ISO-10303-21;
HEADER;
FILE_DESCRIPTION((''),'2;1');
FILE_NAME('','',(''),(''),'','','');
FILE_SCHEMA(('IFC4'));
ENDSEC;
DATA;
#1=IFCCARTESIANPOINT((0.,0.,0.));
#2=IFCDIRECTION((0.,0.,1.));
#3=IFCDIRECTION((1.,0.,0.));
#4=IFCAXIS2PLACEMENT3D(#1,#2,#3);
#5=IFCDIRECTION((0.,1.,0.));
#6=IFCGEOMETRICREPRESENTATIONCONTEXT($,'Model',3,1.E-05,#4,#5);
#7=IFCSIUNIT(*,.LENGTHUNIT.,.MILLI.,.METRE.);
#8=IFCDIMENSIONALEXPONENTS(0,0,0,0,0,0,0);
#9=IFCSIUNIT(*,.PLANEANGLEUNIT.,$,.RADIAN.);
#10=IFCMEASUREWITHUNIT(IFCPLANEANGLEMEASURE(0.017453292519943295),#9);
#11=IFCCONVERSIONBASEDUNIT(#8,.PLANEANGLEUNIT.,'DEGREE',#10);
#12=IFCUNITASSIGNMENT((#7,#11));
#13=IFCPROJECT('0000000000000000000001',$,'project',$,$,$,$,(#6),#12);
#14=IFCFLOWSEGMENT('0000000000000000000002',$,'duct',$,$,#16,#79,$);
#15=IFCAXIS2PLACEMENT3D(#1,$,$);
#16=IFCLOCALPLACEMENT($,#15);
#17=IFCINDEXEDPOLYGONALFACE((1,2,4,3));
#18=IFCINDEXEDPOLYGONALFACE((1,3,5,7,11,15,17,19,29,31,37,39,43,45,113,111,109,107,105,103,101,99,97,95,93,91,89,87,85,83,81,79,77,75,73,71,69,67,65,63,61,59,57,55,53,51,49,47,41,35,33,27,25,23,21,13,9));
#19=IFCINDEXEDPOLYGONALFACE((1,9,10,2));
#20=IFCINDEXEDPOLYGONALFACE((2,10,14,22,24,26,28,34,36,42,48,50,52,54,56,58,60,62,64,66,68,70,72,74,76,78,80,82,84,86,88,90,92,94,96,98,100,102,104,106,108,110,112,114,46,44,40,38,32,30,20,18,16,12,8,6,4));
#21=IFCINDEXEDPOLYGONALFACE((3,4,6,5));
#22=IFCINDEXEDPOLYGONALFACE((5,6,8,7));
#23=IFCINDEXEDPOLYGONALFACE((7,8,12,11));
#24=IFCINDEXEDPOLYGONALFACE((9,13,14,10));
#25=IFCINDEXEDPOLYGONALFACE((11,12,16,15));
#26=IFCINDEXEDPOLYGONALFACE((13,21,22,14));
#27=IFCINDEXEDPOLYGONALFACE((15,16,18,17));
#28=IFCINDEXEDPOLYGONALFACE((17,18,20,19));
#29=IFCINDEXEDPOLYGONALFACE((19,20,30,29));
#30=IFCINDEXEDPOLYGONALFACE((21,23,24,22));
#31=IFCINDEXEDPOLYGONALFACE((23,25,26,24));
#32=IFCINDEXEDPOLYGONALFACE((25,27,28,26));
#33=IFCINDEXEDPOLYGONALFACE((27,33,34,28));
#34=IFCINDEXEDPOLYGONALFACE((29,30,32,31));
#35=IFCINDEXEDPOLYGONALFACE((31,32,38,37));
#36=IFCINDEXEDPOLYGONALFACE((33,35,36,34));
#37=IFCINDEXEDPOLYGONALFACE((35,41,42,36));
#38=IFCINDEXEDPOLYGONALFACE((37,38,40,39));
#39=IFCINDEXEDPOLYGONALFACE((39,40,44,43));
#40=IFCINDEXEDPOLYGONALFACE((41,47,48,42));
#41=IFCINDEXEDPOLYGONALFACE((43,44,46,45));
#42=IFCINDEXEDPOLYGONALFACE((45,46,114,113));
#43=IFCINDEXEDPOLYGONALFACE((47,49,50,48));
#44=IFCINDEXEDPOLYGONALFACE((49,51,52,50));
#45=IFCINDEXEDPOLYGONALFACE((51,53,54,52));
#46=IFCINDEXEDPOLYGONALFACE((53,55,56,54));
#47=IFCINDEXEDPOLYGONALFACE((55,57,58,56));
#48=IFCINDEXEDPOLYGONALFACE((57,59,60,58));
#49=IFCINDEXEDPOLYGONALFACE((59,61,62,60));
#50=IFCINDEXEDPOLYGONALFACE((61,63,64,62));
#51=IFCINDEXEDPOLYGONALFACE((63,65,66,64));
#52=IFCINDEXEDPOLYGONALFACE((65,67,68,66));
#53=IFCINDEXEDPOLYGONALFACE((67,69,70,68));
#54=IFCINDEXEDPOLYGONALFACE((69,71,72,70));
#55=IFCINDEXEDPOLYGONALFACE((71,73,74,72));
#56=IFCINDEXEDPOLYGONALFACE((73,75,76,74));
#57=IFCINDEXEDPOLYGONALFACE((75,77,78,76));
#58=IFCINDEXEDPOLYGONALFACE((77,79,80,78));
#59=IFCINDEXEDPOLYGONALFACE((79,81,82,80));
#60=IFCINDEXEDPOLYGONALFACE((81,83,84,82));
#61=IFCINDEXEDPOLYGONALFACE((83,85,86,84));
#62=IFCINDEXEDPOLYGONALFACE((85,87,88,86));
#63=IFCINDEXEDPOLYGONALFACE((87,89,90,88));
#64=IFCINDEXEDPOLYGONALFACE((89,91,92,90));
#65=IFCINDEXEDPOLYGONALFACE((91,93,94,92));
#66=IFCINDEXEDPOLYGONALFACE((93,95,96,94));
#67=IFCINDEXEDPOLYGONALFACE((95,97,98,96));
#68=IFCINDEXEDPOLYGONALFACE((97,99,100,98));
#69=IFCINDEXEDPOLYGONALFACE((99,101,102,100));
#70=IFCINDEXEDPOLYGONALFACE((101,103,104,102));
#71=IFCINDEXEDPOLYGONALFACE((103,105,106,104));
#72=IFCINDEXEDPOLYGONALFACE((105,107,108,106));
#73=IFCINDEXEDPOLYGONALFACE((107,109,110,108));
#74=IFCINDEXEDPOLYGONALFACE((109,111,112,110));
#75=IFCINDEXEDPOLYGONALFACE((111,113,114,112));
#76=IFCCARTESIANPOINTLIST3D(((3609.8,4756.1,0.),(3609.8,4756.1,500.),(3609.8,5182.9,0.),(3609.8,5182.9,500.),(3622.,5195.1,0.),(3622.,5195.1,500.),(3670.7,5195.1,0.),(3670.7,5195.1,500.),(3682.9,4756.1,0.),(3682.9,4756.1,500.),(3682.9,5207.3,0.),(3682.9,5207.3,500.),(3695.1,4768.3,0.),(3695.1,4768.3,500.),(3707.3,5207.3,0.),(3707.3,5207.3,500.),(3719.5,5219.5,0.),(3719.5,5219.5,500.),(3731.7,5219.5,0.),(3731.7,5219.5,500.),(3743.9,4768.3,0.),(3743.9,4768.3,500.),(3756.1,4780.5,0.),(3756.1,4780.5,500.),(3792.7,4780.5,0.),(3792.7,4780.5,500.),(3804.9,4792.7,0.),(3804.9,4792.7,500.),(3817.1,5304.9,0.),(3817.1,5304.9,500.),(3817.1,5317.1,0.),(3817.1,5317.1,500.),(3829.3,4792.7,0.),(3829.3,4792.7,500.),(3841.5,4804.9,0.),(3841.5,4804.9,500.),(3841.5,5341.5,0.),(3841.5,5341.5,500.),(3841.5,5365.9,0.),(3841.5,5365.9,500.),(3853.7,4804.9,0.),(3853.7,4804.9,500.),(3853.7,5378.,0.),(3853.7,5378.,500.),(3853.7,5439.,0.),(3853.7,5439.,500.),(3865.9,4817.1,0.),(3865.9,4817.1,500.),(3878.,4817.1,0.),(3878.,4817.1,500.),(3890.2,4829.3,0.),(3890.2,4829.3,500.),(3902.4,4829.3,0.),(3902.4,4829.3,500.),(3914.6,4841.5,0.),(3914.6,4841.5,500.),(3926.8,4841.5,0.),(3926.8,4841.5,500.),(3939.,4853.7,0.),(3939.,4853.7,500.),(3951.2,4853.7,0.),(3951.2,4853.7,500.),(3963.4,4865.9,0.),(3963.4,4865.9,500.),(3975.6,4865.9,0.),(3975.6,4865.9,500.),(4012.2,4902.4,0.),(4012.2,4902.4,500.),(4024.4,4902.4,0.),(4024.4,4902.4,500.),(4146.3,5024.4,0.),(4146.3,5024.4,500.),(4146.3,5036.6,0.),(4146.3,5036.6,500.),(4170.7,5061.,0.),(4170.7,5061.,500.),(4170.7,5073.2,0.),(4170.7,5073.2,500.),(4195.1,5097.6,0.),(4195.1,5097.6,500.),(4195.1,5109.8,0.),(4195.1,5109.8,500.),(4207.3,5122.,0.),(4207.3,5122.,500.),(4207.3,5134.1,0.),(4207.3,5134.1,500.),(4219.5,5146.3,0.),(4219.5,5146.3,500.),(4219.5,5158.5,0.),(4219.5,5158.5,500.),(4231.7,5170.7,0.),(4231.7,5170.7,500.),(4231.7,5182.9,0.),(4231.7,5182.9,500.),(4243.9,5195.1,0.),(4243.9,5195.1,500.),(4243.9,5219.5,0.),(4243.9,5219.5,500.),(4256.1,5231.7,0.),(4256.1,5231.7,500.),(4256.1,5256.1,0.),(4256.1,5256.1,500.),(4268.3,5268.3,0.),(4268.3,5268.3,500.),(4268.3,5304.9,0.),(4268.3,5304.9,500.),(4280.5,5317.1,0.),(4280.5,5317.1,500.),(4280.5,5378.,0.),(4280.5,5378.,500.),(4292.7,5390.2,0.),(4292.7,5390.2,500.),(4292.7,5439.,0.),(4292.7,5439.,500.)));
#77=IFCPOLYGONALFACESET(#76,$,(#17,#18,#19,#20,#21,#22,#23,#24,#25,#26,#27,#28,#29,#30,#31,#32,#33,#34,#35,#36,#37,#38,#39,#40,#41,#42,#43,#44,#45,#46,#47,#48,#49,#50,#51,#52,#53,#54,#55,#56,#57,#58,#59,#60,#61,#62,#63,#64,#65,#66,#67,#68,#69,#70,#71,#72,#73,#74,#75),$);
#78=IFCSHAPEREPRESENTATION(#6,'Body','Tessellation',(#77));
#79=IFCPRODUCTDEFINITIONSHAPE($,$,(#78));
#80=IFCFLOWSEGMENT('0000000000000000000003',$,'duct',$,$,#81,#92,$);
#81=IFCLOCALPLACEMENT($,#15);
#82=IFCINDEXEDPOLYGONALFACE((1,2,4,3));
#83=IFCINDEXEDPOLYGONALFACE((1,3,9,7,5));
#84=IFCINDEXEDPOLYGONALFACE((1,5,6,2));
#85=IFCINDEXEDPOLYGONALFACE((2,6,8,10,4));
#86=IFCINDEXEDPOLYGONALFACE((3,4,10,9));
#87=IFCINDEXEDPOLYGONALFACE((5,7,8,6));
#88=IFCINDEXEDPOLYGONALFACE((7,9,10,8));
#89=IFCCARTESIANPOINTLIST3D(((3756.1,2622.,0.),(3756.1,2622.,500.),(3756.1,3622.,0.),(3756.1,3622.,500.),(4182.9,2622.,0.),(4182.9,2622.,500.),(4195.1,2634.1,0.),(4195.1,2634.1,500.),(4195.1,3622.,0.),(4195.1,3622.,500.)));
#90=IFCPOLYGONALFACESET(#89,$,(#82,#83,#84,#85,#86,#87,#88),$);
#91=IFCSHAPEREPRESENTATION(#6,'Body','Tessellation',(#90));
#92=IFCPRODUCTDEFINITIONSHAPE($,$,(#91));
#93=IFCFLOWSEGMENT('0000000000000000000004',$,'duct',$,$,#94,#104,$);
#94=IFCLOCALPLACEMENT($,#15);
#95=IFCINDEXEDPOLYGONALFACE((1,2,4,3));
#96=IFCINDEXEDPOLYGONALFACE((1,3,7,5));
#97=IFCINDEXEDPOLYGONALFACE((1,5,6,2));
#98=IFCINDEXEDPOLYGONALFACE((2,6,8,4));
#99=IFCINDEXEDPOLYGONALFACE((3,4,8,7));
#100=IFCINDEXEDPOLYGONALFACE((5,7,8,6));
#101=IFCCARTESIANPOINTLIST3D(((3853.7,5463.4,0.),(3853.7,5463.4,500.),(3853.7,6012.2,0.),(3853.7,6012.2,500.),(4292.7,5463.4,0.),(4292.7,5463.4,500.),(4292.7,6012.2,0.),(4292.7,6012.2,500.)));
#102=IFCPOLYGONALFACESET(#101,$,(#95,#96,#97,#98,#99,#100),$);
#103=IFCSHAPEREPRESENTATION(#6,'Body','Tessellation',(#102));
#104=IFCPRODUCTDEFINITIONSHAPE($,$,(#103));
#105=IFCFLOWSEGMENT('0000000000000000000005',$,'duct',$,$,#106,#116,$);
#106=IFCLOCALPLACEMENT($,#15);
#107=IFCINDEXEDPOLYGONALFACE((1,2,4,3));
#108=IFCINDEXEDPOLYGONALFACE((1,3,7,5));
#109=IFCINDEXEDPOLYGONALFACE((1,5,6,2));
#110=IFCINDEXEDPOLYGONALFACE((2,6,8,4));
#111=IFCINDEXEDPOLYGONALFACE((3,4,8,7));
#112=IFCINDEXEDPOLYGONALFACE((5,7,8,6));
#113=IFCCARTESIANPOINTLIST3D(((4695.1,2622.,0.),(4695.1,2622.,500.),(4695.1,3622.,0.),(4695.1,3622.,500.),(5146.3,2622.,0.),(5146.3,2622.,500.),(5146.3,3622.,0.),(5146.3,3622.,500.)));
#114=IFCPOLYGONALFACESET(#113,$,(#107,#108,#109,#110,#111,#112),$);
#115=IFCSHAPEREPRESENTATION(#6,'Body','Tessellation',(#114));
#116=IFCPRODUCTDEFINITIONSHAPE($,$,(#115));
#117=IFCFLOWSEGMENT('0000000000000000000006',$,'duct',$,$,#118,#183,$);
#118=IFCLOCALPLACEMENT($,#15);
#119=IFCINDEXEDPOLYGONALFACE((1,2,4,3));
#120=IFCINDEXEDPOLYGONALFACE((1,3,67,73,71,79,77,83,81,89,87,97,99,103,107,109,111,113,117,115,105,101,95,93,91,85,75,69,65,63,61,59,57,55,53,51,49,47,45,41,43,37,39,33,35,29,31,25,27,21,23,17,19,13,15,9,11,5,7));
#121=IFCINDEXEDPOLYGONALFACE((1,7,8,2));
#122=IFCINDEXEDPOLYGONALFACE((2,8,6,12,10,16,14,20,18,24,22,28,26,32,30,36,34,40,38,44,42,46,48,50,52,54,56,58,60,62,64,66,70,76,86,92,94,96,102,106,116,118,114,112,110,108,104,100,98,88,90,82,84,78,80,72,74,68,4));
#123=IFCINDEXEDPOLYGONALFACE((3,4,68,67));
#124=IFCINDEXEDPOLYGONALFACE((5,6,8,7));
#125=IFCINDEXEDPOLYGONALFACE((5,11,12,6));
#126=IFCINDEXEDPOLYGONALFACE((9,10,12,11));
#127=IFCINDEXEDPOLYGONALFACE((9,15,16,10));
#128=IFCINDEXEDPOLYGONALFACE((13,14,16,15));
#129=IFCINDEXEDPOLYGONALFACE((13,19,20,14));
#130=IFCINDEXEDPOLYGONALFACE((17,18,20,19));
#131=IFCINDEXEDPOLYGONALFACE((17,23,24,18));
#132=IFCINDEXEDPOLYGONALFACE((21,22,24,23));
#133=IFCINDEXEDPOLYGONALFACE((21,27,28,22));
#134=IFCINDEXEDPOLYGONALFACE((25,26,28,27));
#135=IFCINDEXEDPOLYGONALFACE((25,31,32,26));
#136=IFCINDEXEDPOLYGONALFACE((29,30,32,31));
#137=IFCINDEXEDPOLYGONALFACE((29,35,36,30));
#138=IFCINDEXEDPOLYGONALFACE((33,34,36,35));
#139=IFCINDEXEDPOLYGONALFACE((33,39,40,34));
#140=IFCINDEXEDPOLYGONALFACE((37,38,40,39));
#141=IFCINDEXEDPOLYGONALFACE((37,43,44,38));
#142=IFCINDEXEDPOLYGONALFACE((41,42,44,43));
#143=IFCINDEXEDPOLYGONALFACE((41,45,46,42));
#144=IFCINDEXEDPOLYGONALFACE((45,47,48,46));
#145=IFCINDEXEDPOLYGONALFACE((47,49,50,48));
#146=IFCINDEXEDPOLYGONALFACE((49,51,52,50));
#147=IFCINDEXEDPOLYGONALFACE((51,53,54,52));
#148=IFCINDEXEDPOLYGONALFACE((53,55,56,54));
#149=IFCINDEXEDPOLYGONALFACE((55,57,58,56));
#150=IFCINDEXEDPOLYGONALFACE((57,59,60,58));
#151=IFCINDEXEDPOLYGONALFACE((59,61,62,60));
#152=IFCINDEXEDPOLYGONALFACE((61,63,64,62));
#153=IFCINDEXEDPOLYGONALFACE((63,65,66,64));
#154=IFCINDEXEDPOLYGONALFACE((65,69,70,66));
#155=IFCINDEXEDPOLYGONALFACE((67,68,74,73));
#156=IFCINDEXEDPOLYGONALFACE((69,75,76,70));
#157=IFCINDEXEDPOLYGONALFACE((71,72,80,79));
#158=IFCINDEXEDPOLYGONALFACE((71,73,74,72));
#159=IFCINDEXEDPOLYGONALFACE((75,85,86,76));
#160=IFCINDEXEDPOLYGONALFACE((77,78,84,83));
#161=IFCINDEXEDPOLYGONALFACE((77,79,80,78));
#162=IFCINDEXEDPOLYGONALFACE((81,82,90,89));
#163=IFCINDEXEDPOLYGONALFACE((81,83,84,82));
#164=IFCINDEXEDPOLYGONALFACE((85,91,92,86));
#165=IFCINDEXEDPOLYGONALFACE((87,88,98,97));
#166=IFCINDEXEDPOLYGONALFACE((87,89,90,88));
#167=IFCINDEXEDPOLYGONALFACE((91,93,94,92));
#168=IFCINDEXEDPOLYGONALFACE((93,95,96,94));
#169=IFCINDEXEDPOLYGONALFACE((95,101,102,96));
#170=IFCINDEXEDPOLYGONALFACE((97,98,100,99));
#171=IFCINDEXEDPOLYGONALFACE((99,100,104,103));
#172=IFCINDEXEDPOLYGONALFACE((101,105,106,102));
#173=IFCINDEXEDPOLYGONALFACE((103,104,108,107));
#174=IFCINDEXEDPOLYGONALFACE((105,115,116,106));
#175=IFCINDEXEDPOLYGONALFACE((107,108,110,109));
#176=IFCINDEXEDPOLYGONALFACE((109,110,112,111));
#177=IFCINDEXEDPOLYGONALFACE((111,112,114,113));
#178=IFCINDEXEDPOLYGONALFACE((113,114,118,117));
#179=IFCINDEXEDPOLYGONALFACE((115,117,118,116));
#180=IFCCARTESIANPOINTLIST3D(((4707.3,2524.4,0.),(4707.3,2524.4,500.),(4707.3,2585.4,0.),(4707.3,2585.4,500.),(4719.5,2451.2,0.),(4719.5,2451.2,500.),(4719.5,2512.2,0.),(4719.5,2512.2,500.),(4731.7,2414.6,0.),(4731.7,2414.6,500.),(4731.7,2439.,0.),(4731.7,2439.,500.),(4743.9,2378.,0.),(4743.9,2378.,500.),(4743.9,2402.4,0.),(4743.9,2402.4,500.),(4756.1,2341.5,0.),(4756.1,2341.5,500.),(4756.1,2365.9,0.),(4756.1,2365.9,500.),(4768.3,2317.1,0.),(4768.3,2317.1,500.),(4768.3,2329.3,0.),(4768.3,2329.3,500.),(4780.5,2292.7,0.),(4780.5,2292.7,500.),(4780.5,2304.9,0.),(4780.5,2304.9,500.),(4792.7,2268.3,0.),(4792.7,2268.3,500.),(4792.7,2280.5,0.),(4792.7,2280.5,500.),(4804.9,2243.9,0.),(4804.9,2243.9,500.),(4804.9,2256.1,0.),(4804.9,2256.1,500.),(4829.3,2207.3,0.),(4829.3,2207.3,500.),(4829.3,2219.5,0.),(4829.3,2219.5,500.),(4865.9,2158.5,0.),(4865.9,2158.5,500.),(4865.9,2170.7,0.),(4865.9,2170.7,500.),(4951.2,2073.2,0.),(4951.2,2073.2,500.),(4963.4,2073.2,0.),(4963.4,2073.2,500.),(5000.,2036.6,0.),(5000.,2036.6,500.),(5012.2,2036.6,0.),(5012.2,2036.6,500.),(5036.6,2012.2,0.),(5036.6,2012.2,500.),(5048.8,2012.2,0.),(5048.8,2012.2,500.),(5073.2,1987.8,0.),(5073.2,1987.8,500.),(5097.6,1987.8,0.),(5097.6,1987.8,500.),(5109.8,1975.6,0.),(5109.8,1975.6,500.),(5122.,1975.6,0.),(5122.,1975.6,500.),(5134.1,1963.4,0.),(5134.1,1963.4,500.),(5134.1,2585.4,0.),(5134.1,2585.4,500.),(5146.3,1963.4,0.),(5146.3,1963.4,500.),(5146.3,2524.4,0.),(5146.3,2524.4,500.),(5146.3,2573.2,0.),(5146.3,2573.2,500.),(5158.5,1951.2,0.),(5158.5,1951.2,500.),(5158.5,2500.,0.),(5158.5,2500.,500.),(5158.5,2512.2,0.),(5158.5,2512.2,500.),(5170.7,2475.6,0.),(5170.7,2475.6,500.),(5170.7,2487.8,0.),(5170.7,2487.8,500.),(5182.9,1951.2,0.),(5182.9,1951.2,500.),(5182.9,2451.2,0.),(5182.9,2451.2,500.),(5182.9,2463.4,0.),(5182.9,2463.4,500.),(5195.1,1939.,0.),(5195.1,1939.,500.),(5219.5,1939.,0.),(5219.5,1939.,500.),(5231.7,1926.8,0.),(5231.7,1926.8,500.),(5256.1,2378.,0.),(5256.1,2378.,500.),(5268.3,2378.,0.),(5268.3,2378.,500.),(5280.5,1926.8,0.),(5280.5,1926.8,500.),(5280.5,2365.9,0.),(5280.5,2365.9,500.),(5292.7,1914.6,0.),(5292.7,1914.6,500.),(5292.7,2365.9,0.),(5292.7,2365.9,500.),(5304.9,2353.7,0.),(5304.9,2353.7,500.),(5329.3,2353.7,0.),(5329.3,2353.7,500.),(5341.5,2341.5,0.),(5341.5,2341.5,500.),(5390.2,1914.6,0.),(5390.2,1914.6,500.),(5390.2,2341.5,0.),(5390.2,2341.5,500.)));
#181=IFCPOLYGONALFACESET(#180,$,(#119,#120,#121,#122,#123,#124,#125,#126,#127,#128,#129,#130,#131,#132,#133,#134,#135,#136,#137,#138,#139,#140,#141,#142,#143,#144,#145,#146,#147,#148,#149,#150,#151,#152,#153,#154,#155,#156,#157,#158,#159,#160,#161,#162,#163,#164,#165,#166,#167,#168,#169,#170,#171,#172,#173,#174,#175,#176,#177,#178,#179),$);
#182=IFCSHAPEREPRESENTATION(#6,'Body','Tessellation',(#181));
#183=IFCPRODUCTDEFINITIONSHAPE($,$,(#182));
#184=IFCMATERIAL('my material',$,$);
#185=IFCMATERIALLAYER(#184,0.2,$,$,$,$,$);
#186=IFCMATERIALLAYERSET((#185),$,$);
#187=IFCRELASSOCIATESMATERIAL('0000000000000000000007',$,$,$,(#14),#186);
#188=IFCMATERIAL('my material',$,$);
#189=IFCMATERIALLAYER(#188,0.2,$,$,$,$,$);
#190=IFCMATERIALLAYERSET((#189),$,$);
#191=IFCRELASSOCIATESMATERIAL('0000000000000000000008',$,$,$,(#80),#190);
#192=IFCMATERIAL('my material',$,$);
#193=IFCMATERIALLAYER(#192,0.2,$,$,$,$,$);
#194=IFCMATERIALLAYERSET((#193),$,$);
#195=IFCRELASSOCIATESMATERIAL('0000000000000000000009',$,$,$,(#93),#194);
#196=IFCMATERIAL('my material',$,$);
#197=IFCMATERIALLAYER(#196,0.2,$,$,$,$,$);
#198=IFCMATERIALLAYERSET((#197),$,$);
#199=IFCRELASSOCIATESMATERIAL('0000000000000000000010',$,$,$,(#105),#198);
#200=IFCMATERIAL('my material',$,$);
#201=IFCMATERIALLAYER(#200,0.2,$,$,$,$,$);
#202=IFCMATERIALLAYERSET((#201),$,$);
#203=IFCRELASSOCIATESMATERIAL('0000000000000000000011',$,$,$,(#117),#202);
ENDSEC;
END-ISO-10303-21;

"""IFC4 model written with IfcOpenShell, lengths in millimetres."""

from ifc_helpers import new_model, entity, si_unit, converted_unit, direction, origin_with_axes, place, context, project, polyline, outline, extrude, material, layer, layer_set, layer_usage, element, save


model = new_model("IFC4")

# Units and contexts
model_context = context("Model", 3, precision=1e-05, world=origin_with_axes(), true_north=direction((0.0, 1.0, 0.0)))
ifc_project = project(units=[si_unit("LENGTHUNIT", "METRE", prefix="MILLI"), converted_unit("PLANEANGLEUNIT", "DEGREE", entity("IfcPlaneAngleMeasure", 0.017453292519943295), si_unit("PLANEANGLEUNIT", "RADIAN"), dimensions=[0, 0, 0, 0, 0, 0, 0])], contexts=[model_context])

# Flow segments
ifc_material_1 = material(Name="my material")
ifc_layer_1 = layer(ifc_material_1, 0.2)
ifc_layer_set_1 = layer_set([ifc_layer_1])
ifc_layer_usage_1 = layer_usage(ifc_layer_set_1, "AXIS2", "POSITIVE", -0.1)
flow_segment_1_placement = place(None, origin_with_axes())
element("IfcFlowSegment", 1, at=flow_segment_1_placement, material=ifc_layer_usage_1, Name="duct", context=model_context, shape_type="SweptSolid", body=[
    extrude(outline(polyline([(3609.8, 4756.1), (3682.9, 4756.1), (3695.1, 4768.3), (3743.9, 4768.3), (3756.1, 4780.5), (3792.7, 4780.5), (3804.9, 4792.7), (3829.3, 4792.7), (3841.5, 4804.9), (3853.7, 4804.9), (3865.9, 4817.1), (3878.0, 4817.1), (3890.2, 4829.3), (3902.4, 4829.3), (3914.6, 4841.5), (3926.8, 4841.5), (3939.0, 4853.7), (3951.2, 4853.7), (3963.4, 4865.9), (3975.6, 4865.9), (4012.2, 4902.4), (4024.4, 4902.4), (4146.3, 5024.4), (4146.3, 5036.6), (4170.7, 5061.0), (4170.7, 5073.2), (4195.1, 5097.6), (4195.1, 5109.8), (4207.3, 5122.0), (4207.3, 5134.1), (4219.5, 5146.3), (4219.5, 5158.5), (4231.7, 5170.7), (4231.7, 5182.9), (4243.9, 5195.1), (4243.9, 5219.5), (4256.1, 5231.7), (4256.1, 5256.1), (4268.3, 5268.3), (4268.3, 5304.9), (4280.5, 5317.1), (4280.5, 5378.0), (4292.7, 5390.2), (4292.7, 5439.0), (3853.7, 5439.0), (3853.7, 5378.0), (3841.5, 5365.9), (3841.5, 5341.5), (3817.1, 5317.1), (3817.1, 5304.9), (3731.7, 5219.5), (3719.5, 5219.5), (3707.3, 5207.3), (3682.9, 5207.3), (3670.7, 5195.1), (3622.0, 5195.1), (3609.8, 5182.9), (3609.8, 4756.1)])), origin_with_axes(), (0.0, 0.0, 1.0), 500.0),
])
ifc_material_2 = material(Name="my material")
ifc_layer_2 = layer(ifc_material_2, 0.2)
ifc_layer_set_2 = layer_set([ifc_layer_2])
ifc_layer_usage_2 = layer_usage(ifc_layer_set_2, "AXIS2", "POSITIVE", -0.1)
flow_segment_2_placement = place(None, origin_with_axes())
element("IfcFlowSegment", 2, at=flow_segment_2_placement, material=ifc_layer_usage_2, Name="duct", context=model_context, shape_type="SweptSolid", body=[
    extrude(outline(polyline([(3756.1, 2622.0), (4182.9, 2622.0), (4195.1, 2634.1), (4195.1, 3622.0), (3756.1, 3622.0), (3756.1, 2622.0)])), origin_with_axes(), (0.0, 0.0, 1.0), 500.0),
])
ifc_material_3 = material(Name="my material")
ifc_layer_3 = layer(ifc_material_3, 0.2)
ifc_layer_set_3 = layer_set([ifc_layer_3])
ifc_layer_usage_3 = layer_usage(ifc_layer_set_3, "AXIS2", "POSITIVE", -0.1)
flow_segment_3_placement = place(None, origin_with_axes())
element("IfcFlowSegment", 3, at=flow_segment_3_placement, material=ifc_layer_usage_3, Name="duct", context=model_context, shape_type="SweptSolid", body=[
    extrude(outline(polyline([(3853.7, 5463.4), (4292.7, 5463.4), (4292.7, 6012.2), (3853.7, 6012.2), (3853.7, 5463.4)])), origin_with_axes(), (0.0, 0.0, 1.0), 500.0),
])
ifc_material_4 = material(Name="my material")
ifc_layer_4 = layer(ifc_material_4, 0.2)
ifc_layer_set_4 = layer_set([ifc_layer_4])
ifc_layer_usage_4 = layer_usage(ifc_layer_set_4, "AXIS2", "POSITIVE", -0.1)
flow_segment_4_placement = place(None, origin_with_axes())
element("IfcFlowSegment", 4, at=flow_segment_4_placement, material=ifc_layer_usage_4, Name="duct", context=model_context, shape_type="SweptSolid", body=[
    extrude(outline(polyline([(4695.1, 2622.0), (5146.3, 2622.0), (5146.3, 3622.0), (4695.1, 3622.0), (4695.1, 2622.0)])), origin_with_axes(), (0.0, 0.0, 1.0), 500.0),
])
ifc_material_5 = material(Name="my material")
ifc_layer_5 = layer(ifc_material_5, 0.2)
ifc_layer_set_5 = layer_set([ifc_layer_5])
ifc_layer_usage_5 = layer_usage(ifc_layer_set_5, "AXIS2", "POSITIVE", -0.1)
flow_segment_5_placement = place(None, origin_with_axes())
element("IfcFlowSegment", 5, at=flow_segment_5_placement, material=ifc_layer_usage_5, Name="duct", context=model_context, shape_type="SweptSolid", body=[
    extrude(outline(polyline([(4707.3, 2524.4), (4719.5, 2512.2), (4719.5, 2451.2), (4731.7, 2439.0), (4731.7, 2414.6), (4743.9, 2402.4), (4743.9, 2378.0), (4756.1, 2365.9), (4756.1, 2341.5), (4768.3, 2329.3), (4768.3, 2317.1), (4780.5, 2304.9), (4780.5, 2292.7), (4792.7, 2280.5), (4792.7, 2268.3), (4804.9, 2256.1), (4804.9, 2243.9), (4829.3, 2219.5), (4829.3, 2207.3), (4865.9, 2170.7), (4865.9, 2158.5), (4951.2, 2073.2), (4963.4, 2073.2), (5000.0, 2036.6), (5012.2, 2036.6), (5036.6, 2012.2), (5048.8, 2012.2), (5073.2, 1987.8), (5097.6, 1987.8), (5109.8, 1975.6), (5122.0, 1975.6), (5134.1, 1963.4), (5146.3, 1963.4), (5158.5, 1951.2), (5182.9, 1951.2), (5195.1, 1939.0), (5219.5, 1939.0), (5231.7, 1926.8), (5280.5, 1926.8), (5292.7, 1914.6), (5390.2, 1914.6), (5390.2, 2341.5), (5341.5, 2341.5), (5329.3, 2353.7), (5304.9, 2353.7), (5292.7, 2365.9), (5280.5, 2365.9), (5268.3, 2378.0), (5256.1, 2378.0), (5182.9, 2451.2), (5182.9, 2463.4), (5170.7, 2475.6), (5170.7, 2487.8), (5158.5, 2500.0), (5158.5, 2512.2), (5146.3, 2524.4), (5146.3, 2573.2), (5134.1, 2585.4), (4707.3, 2585.4), (4707.3, 2524.4)])), origin_with_axes(), (0.0, 0.0, 1.0), 500.0),
])

save(model, "model.ifc")
